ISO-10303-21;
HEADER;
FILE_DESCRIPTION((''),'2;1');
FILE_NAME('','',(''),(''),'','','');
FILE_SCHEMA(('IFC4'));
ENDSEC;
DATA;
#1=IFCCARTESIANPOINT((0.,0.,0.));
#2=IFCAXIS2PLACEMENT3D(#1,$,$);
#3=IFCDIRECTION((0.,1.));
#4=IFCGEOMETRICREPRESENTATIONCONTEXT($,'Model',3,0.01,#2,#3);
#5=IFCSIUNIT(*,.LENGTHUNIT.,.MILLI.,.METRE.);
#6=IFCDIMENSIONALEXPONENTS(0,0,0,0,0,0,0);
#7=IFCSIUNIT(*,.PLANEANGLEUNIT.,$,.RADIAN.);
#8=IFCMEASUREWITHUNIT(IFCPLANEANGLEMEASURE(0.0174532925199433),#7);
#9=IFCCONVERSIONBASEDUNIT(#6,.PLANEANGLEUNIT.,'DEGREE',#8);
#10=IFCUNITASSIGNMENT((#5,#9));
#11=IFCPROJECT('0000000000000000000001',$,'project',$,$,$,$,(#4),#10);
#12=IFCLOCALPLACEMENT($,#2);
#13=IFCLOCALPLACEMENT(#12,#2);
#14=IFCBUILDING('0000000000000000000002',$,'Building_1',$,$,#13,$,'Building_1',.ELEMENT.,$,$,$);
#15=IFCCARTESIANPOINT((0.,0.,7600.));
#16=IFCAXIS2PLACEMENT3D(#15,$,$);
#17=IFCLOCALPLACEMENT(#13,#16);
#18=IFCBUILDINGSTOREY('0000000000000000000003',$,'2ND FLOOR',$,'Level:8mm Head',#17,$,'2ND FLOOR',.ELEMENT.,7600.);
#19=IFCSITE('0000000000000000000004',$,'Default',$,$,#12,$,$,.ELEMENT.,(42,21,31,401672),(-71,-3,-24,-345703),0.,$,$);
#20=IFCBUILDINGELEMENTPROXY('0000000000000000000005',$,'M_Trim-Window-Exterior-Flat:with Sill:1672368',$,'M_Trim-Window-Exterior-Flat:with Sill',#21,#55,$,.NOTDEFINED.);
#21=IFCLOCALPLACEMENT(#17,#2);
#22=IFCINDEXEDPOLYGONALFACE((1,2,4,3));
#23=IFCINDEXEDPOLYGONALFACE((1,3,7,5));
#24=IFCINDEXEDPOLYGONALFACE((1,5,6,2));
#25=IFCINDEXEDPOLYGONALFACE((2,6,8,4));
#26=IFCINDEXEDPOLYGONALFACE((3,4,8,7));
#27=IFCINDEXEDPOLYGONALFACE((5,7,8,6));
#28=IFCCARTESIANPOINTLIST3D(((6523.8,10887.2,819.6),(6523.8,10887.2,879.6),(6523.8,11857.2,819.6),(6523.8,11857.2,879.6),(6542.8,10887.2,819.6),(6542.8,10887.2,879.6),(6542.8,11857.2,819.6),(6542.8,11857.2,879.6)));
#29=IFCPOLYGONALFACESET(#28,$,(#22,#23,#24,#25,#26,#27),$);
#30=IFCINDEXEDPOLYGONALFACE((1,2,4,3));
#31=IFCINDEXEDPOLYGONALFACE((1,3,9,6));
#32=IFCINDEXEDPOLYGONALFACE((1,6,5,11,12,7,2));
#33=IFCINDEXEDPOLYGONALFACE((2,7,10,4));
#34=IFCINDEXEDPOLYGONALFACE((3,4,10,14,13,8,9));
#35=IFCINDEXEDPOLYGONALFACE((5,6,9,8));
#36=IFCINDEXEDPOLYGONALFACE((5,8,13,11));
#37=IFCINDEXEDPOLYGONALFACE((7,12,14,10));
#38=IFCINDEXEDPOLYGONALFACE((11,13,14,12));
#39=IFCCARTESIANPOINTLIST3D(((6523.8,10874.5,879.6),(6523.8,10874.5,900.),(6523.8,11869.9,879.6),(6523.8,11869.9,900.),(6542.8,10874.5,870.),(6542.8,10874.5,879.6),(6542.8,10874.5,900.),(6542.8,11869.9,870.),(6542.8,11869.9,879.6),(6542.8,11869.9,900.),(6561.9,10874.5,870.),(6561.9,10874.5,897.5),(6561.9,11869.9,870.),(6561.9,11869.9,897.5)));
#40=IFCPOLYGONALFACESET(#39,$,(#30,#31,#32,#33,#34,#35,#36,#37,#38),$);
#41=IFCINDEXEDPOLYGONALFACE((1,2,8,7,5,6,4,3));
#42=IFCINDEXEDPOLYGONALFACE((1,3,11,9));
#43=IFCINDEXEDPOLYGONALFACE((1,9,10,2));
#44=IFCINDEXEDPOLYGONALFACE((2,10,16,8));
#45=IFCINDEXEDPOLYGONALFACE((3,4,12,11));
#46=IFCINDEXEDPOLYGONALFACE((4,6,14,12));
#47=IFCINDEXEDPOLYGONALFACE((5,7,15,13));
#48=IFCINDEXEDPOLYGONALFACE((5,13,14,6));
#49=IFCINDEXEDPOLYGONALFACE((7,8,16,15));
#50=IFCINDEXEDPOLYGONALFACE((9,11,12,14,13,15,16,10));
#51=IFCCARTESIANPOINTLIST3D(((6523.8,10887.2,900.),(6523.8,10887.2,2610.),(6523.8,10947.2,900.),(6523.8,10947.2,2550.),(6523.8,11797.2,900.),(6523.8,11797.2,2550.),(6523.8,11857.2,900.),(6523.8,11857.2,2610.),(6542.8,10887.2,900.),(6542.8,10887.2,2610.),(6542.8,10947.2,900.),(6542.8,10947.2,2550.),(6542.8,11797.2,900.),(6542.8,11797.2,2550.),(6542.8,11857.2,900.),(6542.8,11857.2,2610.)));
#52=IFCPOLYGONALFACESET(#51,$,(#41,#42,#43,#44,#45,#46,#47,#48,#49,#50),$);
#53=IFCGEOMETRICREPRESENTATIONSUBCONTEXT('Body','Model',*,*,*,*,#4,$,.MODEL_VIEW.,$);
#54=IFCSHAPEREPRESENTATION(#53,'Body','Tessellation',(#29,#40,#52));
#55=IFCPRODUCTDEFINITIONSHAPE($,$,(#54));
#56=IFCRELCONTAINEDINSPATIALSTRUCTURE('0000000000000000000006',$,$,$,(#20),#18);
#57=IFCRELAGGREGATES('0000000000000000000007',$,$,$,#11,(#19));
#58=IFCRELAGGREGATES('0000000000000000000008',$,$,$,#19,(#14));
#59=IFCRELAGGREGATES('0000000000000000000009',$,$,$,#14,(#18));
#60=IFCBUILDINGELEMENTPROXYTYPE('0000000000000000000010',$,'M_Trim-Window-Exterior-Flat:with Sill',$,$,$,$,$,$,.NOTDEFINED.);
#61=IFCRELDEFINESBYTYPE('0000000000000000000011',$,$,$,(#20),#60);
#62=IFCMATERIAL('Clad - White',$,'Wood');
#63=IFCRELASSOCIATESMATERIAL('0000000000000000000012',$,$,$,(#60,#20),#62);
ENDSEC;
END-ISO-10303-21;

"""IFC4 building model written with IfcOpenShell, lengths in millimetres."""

from ifc_helpers import new_model, entity, si_unit, converted_unit, direction, frame, origin, place, context, subcontext, project, spatial, indexed_curve, outline, extrude, source, transform, mapped, material, type_object, type_shapes, element, save


model = new_model("IFC4")

# Units and contexts
model_context = context("Model", 3, precision=0.01, world=origin(), true_north=direction((0.0, 1.0)))
body_context = subcontext(model_context, "Body", "Model", "MODEL_VIEW")
ifc_project = project(units=[si_unit("LENGTHUNIT", "METRE", prefix="MILLI"), converted_unit("PLANEANGLEUNIT", "DEGREE", entity("IfcPlaneAngleMeasure", 0.0174532925199433), si_unit("PLANEANGLEUNIT", "RADIAN"), dimensions=[0, 0, 0, 0, 0, 0, 0])], contexts=[model_context])

# Site, building, storey
site_placement = place(None, origin())
site = spatial("IfcSite", under=ifc_project, at=site_placement, Name="Default", CompositionType="ELEMENT", RefLatitude=(42, 21, 31, 401672), RefLongitude=(-71, -3, -24, -345703), RefElevation=0.0)
building_placement = place(site_placement, origin())
building = spatial("IfcBuilding", under=site, at=building_placement, Name="Building_1", LongName="Building_1", CompositionType="ELEMENT")
storey_placement = place(building_placement, frame((0.0, 0.0, 7600.0)))
storey = spatial("IfcBuildingStorey", under=building, at=storey_placement, Name="2ND FLOOR", ObjectType="Level:8mm Head", LongName="2ND FLOOR", CompositionType="ELEMENT", Elevation=7600.0)

# Building element proxy
ifc_material_1 = material(Name="Clad - White", Category="Wood")
building_element_proxy_type_1 = type_object("IfcBuildingElementProxyType", Name="M_Trim-Window-Exterior-Flat:with Sill", PredefinedType="NOTDEFINED", material=ifc_material_1)
shared_shape_1 = source(origin(), body_context, "Body", "SweptSolid", [
    extrude(outline(indexed_curve([(-485.0, -30.0), (485.0, -30.0), (485.0, 30.0), (-485.0, 30.0), (-485.0, -30.0)], self_intersect=False)), frame((0.0, -1700.4, 0.0), z_axis=(0.0, 0.0, 1.0), x_axis=(-1.0, 0.0, 0.0)), (0.0, 0.0, 1.0), 19.1),
    extrude(outline(indexed_curve([(-19.0, -15.2), (0.0, -15.2), (0.0, -5.7), (19.0, -5.7), (19.0, 14.8), (0.0, 14.8), (-19.0, 12.3), (-19.0, -15.2)], self_intersect=False)), frame((-497.7, -1664.8, 19.0), z_axis=(1.0, 0.0, 0.0), x_axis=(0.0, 0.0, -1.0)), (0.0, 0.0, 1.0), 995.4),
    extrude(outline(indexed_curve([(-870.0, -485.0), (840.0, -485.0), (840.0, -425.0), (-810.0, -425.0), (-810.0, 425.0), (840.0, 425.0), (840.0, 485.0), (-870.0, 485.0), (-870.0, -485.0)], self_intersect=False)), frame((0.0, -810.0, 0.0), z_axis=(0.0, 0.0, 1.0), x_axis=(0.0, -1.0, 0.0)), (0.0, 0.0, 1.0), 19.1),
])
type_shapes(building_element_proxy_type_1, [shared_shape_1])
proxy_1_placement = place(storey_placement, frame((6523.8, 11372.2, 2550.0), z_axis=(1.0, 0.0, 0.0), x_axis=(0.0, 1.0, 0.0)))
element("IfcBuildingElementProxy", 1, at=proxy_1_placement, inside=storey, type_object=building_element_proxy_type_1, material=ifc_material_1, Name="M_Trim-Window-Exterior-Flat:with Sill:1672368", ObjectType="M_Trim-Window-Exterior-Flat:with Sill", PredefinedType="NOTDEFINED", context=body_context, shape_type="MappedRepresentation", body=[
    mapped(shared_shape_1, transform((0.0, 0.0, 0.0), scale=1.0)),
])

save(model, "model.ifc")
